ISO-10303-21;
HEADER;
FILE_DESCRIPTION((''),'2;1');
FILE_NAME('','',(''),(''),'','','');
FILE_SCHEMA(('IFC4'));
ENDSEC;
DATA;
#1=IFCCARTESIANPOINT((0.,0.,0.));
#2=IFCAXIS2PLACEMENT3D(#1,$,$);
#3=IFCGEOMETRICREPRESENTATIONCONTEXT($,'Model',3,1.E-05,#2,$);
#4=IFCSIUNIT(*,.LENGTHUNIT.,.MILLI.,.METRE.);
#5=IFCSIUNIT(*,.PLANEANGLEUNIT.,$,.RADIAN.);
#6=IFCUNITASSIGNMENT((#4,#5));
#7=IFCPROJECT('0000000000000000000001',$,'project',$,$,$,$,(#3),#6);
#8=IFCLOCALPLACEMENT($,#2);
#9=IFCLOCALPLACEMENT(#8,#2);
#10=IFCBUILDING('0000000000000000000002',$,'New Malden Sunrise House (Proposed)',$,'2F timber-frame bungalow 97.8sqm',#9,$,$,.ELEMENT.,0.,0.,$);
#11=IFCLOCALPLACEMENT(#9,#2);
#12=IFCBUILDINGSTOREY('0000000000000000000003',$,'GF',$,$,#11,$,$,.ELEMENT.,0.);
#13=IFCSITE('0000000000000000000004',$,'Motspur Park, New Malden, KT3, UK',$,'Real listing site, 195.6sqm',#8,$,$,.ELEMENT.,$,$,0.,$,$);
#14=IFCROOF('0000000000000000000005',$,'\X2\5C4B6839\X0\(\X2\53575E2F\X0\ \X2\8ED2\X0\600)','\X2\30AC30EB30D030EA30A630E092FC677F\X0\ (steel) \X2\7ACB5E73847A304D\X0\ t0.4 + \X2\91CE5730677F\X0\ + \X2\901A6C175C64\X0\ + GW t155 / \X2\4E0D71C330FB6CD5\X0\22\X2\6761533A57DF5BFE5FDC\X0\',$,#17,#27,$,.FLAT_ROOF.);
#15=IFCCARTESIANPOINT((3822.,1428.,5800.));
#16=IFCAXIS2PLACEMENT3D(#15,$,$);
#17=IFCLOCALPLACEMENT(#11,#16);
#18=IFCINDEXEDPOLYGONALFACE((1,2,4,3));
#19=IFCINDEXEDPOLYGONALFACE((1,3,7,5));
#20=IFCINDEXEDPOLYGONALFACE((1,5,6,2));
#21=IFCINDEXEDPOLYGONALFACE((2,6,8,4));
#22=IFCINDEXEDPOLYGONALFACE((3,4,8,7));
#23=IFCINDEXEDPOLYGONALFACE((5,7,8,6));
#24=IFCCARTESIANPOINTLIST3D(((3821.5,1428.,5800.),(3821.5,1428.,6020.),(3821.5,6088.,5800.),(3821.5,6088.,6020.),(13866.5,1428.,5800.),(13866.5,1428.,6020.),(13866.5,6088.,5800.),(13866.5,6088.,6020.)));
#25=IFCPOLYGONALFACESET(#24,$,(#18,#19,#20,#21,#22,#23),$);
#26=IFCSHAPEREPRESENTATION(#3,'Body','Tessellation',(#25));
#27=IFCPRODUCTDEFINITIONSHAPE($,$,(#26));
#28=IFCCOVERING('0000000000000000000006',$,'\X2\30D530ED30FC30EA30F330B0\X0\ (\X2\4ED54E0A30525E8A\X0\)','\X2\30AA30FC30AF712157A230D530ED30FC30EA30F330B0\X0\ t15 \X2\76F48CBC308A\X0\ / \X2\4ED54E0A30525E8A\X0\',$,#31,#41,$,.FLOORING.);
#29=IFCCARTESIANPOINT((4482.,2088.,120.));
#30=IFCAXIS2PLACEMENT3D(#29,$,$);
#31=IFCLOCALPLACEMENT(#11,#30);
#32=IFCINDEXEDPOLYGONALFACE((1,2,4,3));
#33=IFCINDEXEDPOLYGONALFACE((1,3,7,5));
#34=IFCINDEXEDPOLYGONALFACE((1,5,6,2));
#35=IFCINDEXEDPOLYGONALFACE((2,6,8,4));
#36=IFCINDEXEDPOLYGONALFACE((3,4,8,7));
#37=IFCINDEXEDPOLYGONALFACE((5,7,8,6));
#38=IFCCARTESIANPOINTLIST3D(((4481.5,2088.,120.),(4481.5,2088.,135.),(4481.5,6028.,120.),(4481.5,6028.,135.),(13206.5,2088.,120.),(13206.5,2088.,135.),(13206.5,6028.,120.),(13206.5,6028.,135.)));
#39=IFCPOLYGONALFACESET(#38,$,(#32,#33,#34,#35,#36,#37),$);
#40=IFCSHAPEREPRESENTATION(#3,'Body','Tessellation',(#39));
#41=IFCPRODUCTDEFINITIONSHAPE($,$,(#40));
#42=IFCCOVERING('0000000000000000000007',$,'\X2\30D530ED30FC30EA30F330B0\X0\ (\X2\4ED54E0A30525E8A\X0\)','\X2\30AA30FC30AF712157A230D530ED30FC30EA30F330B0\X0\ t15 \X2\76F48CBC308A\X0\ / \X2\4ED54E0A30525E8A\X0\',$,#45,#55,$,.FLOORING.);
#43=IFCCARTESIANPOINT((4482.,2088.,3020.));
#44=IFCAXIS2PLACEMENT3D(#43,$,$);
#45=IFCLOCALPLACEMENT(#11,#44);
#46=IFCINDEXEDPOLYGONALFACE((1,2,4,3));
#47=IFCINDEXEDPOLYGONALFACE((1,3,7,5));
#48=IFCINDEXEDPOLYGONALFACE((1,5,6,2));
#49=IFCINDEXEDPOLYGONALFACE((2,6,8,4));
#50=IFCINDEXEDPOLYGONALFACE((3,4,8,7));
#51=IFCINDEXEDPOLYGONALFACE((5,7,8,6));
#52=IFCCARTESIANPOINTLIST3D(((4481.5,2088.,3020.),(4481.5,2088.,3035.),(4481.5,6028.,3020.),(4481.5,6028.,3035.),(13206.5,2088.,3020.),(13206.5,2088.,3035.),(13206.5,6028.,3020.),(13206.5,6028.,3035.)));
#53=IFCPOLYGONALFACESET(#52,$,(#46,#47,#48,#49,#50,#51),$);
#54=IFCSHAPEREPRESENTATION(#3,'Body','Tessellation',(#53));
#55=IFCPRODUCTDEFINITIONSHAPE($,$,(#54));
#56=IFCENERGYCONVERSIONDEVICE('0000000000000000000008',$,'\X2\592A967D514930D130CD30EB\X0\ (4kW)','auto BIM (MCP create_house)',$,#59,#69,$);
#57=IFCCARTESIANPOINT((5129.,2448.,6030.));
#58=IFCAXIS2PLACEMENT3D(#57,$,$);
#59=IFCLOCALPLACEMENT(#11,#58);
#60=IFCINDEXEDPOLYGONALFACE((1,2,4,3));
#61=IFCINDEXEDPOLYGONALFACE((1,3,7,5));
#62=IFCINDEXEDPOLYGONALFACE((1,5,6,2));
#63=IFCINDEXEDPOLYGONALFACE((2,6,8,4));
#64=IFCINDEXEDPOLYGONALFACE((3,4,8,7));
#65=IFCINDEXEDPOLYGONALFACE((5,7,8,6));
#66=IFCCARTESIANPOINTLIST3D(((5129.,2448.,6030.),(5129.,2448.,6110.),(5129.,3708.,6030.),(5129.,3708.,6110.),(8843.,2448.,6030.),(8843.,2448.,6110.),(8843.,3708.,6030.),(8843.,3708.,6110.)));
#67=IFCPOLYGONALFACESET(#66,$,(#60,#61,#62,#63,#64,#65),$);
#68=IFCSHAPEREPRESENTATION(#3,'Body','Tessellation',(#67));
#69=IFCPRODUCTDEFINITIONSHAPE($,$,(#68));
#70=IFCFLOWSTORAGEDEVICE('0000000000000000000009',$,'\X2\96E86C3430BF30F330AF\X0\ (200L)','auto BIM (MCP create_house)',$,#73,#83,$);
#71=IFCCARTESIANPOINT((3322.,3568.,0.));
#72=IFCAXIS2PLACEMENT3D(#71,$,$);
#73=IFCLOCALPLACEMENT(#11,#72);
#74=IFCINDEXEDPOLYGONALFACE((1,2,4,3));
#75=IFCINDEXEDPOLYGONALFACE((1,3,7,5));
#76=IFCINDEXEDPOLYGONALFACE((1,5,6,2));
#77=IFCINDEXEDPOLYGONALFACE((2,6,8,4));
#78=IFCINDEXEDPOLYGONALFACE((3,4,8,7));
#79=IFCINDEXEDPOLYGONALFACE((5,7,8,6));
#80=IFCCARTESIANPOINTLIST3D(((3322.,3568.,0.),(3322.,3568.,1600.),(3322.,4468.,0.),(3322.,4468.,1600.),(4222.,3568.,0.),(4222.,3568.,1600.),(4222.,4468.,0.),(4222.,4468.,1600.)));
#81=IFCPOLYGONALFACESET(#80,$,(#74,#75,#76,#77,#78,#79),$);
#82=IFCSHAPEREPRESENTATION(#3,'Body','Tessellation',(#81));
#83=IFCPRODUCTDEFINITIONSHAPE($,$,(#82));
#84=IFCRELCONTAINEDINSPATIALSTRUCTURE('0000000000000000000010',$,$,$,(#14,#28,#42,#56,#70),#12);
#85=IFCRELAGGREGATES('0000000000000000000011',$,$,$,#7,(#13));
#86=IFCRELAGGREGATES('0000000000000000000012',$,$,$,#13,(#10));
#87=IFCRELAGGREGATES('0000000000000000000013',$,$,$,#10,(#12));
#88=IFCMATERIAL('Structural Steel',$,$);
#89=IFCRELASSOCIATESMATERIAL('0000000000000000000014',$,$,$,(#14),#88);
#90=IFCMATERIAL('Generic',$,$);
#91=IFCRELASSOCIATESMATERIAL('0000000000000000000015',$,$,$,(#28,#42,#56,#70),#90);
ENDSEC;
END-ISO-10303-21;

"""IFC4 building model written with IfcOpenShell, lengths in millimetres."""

from ifc_helpers import new_model, si_unit, frame, frame_2d, origin, place, context, project, spatial, rectangle, extrude, material, element, save


model = new_model("IFC4")

# Units and contexts
model_context = context("Model", 3, precision=1e-05, world=origin())
ifc_project = project(units=[si_unit("LENGTHUNIT", "METRE", prefix="MILLI"), si_unit("PLANEANGLEUNIT", "RADIAN")], contexts=[model_context])

# Site, building, storey
site_placement = place(None, origin())
site = spatial("IfcSite", under=ifc_project, at=site_placement, Name="Motspur Park, New Malden, KT3, UK", ObjectType="Real listing site, 195.6sqm", CompositionType="ELEMENT", RefElevation=0.0)
building_placement = place(site_placement, origin())
building = spatial("IfcBuilding", under=site, at=building_placement, Name="New Malden Sunrise House (Proposed)", ObjectType="2F timber-frame bungalow 97.8sqm", CompositionType="ELEMENT", ElevationOfRefHeight=0.0, ElevationOfTerrain=0.0)
storey_placement = place(building_placement, origin())
storey = spatial("IfcBuildingStorey", under=building, at=storey_placement, Name="GF", CompositionType="ELEMENT", Elevation=0.0)

# Roof
ifc_material_1 = material(Name="Structural Steel")
for number, where, name in (
    (1, (3822.0, 1428.0, 5800.0), "屋根(南帯 軒600)"),
):
    element("IfcRoof", number, at=place(storey_placement, frame(where)), inside=storey, material=ifc_material_1, Name=name, Description="ガルバリウム鋼板 (steel) 立平葺き t0.4 + 野地板 + 通気層 + GW t155 / 不燃・法22条区域対応", PredefinedType="FLAT_ROOF", context=model_context, shape_type="SweptSolid", body=[
        extrude(rectangle(XDim=10045.0, YDim=4660.0, at=frame_2d((5022.0, 2330.0))), frame((3822.0, 1428.0, 5800.0)), (0.0, 0.0, 1.0), 220.0),
    ])

# Coverings
ifc_material_2 = material(Name="Generic")
covering_1_placement = place(storey_placement, frame((4482.0, 2088.0, 120.0)))
element("IfcCovering", 2, at=covering_1_placement, inside=storey, material=ifc_material_2, Name="フローリング (仕上げ床)", Description="オーク無垢フローリング t15 直貼り / 仕上げ床", PredefinedType="FLOORING", context=model_context, shape_type="SweptSolid", body=[
    extrude(rectangle(XDim=8725.0, YDim=3940.0, at=frame_2d((4362.0, 1970.0))), frame((4482.0, 2088.0, 120.0)), (0.0, 0.0, 1.0), 15.0),
])
covering_2_placement = place(storey_placement, frame((4482.0, 2088.0, 3020.0)))
element("IfcCovering", 3, at=covering_2_placement, inside=storey, material=ifc_material_2, Name="フローリング (仕上げ床)", Description="オーク無垢フローリング t15 直貼り / 仕上げ床", PredefinedType="FLOORING", context=model_context, shape_type="SweptSolid", body=[
    extrude(rectangle(XDim=8725.0, YDim=3940.0, at=frame_2d((4362.0, 1970.0))), frame((4482.0, 2088.0, 3020.0)), (0.0, 0.0, 1.0), 15.0),
])

# Energy conversion device
energy_conversion_device_placement = place(storey_placement, frame((5129.0, 2448.0, 6030.0)))
element("IfcEnergyConversionDevice", 4, at=energy_conversion_device_placement, inside=storey, material=ifc_material_2, Name="太陽光パネル (4kW)", Description="auto BIM (MCP create_house)", context=model_context, shape_type="SweptSolid", body=[
    extrude(rectangle(XDim=3714.0, YDim=1260.0, at=frame_2d((1857.0, 630.0))), frame((5129.0, 2448.0, 6030.0)), (0.0, 0.0, 1.0), 80.0),
])

# Flow storage device
flow_storage_device_placement = place(storey_placement, frame((3322.0, 3568.0, 0.0)))
element("IfcFlowStorageDevice", 5, at=flow_storage_device_placement, inside=storey, material=ifc_material_2, Name="雨水タンク (200L)", Description="auto BIM (MCP create_house)", context=model_context, shape_type="SweptSolid", body=[
    extrude(rectangle(XDim=900.0, YDim=900.0, at=frame_2d((450.0, 450.0))), frame((3322.0, 3568.0, 0.0)), (0.0, 0.0, 1.0), 1600.0),
])

save(model, "model.ifc")
